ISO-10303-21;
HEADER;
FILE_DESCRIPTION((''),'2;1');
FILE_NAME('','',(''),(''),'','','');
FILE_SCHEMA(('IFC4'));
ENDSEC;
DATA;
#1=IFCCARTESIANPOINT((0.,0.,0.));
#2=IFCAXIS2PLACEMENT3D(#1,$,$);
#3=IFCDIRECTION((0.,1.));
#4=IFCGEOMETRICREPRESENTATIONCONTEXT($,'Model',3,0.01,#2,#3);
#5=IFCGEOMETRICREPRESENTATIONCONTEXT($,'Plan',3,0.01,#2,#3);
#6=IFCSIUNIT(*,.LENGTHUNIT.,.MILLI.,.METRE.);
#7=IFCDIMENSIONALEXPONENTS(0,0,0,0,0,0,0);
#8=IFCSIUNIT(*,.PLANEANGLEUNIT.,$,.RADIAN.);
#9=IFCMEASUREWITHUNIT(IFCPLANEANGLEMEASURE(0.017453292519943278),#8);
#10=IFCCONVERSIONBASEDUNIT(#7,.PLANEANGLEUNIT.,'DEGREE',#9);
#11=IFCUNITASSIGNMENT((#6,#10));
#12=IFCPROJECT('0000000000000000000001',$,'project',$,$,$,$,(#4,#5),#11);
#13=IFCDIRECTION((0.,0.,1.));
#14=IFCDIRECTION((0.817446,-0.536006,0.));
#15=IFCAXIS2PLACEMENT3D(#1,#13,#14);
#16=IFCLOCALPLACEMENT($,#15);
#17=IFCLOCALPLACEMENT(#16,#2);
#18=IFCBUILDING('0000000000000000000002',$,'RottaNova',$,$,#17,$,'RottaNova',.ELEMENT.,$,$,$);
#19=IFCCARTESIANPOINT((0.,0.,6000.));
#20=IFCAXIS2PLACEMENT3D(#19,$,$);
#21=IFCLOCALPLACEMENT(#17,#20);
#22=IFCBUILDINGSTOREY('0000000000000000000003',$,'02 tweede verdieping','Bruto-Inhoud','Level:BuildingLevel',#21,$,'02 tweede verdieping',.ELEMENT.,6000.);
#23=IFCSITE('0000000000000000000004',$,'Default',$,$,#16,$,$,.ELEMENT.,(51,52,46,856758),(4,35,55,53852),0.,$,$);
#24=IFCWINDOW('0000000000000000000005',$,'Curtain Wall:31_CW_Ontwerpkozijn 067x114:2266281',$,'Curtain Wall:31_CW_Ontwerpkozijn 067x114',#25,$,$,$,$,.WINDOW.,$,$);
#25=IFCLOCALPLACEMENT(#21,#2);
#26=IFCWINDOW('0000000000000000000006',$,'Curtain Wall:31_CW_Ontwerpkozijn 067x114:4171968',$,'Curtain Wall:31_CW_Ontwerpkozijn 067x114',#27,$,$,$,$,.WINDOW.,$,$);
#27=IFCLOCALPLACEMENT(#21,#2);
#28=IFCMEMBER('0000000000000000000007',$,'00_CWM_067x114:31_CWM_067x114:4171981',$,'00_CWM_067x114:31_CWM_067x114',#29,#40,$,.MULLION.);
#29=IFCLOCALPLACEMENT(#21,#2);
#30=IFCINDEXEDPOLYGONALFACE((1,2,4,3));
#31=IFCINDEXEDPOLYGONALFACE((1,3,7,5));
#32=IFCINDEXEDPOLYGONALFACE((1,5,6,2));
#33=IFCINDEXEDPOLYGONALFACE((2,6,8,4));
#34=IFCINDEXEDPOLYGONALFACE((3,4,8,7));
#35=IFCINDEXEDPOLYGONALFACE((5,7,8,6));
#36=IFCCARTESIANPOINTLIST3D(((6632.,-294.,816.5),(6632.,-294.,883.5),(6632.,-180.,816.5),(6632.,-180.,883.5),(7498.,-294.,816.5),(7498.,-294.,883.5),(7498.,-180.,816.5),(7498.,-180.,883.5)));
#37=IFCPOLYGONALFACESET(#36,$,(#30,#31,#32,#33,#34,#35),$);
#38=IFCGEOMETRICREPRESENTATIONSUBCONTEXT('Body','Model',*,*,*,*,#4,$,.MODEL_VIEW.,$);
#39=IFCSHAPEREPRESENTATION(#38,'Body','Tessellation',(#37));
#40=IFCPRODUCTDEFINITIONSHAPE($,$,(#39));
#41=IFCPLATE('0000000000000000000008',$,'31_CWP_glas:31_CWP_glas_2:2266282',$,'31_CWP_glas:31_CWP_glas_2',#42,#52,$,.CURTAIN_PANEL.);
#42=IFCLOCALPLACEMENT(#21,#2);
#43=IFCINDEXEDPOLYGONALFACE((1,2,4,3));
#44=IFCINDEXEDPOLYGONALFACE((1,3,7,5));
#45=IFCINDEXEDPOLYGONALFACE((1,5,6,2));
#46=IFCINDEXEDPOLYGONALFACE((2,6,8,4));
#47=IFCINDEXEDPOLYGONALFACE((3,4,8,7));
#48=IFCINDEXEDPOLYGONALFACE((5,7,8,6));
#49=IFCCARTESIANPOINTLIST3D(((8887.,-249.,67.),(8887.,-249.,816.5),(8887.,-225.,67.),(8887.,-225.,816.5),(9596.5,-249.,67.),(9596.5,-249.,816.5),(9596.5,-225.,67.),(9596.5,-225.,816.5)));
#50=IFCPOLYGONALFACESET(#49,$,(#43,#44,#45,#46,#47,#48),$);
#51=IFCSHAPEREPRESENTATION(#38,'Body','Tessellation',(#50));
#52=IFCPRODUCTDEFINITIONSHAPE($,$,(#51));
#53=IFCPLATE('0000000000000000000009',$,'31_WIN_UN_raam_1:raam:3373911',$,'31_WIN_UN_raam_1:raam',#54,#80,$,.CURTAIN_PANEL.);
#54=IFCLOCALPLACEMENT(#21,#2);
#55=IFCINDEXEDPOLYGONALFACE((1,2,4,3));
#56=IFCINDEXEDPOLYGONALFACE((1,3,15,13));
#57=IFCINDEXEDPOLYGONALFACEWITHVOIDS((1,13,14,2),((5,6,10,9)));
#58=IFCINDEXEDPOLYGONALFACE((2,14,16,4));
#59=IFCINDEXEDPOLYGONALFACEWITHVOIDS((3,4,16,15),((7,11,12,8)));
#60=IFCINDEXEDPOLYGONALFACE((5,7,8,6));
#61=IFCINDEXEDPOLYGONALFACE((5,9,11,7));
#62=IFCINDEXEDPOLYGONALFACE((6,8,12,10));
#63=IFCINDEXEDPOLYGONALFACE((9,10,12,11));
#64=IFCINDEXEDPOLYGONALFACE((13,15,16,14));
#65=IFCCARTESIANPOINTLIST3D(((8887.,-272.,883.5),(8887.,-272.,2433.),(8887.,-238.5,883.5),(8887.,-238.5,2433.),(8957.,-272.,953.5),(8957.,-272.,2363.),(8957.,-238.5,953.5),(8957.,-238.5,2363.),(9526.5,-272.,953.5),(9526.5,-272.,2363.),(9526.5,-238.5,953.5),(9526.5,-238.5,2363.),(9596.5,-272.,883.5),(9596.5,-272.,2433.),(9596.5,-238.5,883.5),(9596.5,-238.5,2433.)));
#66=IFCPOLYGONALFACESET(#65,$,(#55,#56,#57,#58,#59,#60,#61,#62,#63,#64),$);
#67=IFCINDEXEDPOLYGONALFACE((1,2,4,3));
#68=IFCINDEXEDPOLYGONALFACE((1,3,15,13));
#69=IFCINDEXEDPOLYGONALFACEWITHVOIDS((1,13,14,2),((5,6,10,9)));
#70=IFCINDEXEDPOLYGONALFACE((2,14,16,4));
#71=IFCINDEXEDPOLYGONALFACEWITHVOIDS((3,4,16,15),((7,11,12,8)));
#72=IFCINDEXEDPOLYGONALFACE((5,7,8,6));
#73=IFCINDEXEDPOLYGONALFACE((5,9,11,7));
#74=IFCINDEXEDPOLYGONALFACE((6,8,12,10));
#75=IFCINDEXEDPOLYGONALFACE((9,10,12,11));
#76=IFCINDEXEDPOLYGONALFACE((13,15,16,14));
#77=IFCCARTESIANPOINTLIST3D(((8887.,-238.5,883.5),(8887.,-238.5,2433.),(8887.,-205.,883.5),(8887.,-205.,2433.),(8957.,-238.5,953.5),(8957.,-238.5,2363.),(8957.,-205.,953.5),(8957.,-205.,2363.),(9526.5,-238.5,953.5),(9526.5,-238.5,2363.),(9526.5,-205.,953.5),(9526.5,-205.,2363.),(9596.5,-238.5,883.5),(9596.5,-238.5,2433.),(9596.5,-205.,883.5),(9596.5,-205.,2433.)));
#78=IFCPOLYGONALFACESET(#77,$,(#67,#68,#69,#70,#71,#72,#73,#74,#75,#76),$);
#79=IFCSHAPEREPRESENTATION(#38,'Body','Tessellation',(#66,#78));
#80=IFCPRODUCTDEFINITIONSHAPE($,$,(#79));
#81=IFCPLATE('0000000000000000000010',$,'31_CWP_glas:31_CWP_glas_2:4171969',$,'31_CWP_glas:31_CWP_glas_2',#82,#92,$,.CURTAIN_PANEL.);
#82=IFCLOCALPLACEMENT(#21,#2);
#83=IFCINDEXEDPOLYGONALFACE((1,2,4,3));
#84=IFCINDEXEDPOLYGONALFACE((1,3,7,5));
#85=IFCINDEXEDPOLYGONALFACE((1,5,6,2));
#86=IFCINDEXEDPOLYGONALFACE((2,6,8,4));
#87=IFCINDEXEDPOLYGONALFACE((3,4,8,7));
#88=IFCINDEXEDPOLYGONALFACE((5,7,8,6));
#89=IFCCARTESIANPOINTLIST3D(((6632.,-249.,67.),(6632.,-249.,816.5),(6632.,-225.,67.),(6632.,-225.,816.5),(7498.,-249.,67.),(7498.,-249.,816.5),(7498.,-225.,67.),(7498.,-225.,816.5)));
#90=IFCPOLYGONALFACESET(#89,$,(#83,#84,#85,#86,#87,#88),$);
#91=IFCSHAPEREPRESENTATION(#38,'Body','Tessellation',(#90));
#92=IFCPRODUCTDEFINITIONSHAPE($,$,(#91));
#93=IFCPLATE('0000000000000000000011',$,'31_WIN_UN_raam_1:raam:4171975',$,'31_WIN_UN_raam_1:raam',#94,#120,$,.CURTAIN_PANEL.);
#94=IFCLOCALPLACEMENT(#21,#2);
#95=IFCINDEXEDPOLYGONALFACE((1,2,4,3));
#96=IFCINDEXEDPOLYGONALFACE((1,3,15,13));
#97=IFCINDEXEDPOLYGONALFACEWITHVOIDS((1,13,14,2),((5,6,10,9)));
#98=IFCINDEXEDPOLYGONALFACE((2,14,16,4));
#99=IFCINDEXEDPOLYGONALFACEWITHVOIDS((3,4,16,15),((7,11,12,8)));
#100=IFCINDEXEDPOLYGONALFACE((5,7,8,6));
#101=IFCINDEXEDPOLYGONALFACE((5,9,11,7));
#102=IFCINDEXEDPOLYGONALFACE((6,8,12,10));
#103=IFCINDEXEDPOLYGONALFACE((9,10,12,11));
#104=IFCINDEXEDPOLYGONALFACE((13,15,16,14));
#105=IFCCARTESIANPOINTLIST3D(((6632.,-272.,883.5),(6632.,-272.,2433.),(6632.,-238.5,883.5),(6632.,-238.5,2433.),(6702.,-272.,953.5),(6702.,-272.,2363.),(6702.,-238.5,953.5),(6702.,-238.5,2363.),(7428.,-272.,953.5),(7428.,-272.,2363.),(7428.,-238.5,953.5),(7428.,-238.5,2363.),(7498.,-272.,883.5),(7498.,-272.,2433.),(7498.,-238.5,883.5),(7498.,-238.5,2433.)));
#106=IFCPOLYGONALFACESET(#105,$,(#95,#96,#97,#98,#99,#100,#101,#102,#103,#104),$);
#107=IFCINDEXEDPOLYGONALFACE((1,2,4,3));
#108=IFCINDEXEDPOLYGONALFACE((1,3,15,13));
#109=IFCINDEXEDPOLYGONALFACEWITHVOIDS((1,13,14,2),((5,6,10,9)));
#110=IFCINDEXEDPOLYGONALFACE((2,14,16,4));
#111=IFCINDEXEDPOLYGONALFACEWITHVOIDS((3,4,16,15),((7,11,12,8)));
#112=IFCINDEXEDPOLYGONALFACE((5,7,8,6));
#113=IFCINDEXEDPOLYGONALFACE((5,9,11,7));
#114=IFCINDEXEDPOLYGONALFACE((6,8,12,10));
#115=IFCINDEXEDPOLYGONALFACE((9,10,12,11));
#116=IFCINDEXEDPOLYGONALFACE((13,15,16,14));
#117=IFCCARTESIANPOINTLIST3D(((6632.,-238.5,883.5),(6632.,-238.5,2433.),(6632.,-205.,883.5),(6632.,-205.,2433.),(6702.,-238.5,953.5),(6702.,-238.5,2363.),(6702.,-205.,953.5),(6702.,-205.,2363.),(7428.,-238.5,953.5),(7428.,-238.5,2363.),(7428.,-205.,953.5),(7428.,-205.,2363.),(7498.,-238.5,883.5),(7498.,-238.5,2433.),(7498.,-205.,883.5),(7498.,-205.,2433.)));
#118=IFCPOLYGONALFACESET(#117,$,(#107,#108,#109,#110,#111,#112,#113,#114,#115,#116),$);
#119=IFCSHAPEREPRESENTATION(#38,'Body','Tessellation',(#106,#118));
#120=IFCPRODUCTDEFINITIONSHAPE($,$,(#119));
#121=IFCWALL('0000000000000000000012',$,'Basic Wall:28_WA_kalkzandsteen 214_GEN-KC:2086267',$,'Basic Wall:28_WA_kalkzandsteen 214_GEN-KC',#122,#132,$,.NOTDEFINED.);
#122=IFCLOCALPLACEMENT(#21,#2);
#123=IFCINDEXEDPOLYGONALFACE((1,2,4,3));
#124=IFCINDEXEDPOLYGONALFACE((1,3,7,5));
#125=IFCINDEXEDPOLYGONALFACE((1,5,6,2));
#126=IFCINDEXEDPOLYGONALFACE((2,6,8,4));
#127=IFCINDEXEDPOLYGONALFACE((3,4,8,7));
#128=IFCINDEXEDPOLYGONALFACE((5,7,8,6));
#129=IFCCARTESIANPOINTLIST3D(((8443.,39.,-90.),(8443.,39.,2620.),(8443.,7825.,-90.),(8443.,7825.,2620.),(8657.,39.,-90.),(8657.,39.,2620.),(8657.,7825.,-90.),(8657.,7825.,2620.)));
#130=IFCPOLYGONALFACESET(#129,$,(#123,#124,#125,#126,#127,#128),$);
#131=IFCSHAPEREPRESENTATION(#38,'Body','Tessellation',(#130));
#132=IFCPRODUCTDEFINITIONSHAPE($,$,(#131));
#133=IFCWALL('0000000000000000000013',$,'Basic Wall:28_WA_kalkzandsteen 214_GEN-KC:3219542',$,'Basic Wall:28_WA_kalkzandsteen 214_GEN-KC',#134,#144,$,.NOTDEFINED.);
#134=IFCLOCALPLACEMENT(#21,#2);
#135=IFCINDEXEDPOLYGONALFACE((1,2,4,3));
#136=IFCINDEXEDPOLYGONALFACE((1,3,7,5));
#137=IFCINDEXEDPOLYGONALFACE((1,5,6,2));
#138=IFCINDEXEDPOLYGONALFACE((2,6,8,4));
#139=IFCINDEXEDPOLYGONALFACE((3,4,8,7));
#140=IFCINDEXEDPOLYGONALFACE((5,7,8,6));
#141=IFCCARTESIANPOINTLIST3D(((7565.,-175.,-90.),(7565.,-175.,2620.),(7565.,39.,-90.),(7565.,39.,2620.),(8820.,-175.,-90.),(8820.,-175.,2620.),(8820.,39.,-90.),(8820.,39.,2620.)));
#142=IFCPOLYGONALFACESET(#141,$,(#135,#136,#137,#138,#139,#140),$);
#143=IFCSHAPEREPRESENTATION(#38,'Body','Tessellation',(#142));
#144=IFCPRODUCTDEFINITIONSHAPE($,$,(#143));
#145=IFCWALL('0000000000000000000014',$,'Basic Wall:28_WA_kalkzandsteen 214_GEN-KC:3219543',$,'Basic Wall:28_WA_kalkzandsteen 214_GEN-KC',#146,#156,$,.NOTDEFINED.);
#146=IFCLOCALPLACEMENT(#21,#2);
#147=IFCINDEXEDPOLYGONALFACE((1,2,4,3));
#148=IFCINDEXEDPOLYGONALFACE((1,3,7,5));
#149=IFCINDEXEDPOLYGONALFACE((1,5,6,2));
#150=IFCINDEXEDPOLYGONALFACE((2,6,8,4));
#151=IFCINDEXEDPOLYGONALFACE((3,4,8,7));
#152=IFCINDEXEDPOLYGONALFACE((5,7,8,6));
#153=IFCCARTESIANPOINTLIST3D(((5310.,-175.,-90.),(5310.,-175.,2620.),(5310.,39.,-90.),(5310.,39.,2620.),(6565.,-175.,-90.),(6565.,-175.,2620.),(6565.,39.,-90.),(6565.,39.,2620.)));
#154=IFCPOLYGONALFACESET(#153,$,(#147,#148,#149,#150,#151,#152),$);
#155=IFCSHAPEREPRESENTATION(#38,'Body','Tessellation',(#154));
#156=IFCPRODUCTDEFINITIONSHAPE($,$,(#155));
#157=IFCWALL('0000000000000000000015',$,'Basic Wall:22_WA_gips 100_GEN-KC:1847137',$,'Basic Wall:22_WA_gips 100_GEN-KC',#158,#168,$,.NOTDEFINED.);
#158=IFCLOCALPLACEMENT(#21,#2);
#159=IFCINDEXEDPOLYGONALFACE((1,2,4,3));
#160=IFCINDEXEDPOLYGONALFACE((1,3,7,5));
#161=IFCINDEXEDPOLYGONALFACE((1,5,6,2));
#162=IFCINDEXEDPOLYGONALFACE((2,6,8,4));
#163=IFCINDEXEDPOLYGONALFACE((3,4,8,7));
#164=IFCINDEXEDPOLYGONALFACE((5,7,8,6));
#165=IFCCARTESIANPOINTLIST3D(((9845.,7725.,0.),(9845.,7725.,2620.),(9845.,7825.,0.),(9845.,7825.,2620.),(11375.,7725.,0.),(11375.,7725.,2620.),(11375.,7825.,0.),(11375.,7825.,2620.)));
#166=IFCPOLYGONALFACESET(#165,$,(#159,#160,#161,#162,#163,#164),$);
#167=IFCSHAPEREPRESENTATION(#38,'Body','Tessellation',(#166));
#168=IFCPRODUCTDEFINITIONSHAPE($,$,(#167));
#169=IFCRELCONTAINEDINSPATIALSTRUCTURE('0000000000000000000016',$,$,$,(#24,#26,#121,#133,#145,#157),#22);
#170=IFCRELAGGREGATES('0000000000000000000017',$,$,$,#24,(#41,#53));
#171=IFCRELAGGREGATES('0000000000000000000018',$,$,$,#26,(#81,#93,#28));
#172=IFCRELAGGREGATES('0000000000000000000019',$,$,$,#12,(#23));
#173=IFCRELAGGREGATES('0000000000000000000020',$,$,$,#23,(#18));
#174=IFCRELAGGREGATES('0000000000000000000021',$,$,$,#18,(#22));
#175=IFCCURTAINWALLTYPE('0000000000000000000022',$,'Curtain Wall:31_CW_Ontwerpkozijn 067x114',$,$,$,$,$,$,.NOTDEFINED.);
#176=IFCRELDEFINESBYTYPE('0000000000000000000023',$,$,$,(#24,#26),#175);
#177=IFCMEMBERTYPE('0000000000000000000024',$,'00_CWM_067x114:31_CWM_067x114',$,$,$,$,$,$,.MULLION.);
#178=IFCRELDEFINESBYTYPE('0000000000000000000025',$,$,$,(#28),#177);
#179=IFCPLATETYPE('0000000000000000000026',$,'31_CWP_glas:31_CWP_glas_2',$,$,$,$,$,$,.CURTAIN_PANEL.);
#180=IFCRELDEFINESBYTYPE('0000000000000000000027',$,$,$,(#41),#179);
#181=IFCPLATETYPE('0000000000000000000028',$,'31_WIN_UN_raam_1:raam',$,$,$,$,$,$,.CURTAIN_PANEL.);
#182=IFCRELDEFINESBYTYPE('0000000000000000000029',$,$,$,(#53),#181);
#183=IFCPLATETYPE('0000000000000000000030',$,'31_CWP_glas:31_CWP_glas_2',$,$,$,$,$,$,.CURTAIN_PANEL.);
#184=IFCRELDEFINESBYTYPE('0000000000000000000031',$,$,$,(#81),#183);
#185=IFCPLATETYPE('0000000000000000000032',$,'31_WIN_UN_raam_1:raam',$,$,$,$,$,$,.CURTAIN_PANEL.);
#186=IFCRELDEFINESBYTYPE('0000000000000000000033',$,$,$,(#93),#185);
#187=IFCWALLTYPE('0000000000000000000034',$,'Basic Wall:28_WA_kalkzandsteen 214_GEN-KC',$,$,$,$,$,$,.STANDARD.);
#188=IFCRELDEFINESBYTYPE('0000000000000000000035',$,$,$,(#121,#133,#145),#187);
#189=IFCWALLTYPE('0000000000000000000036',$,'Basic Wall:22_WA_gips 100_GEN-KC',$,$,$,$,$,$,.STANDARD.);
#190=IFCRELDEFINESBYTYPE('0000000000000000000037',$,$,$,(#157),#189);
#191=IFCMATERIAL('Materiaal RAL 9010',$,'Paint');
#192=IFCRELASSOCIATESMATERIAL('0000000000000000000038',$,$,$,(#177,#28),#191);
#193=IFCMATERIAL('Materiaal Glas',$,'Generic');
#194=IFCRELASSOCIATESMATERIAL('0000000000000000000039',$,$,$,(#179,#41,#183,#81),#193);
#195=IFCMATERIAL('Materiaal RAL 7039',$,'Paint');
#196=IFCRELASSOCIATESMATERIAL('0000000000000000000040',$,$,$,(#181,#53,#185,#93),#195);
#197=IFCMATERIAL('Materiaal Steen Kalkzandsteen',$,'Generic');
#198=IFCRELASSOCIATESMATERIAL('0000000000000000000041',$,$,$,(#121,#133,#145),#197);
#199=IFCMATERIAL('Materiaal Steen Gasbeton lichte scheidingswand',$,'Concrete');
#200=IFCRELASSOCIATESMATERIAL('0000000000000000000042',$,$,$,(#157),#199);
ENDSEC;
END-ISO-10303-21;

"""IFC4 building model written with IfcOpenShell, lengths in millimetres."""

from ifc_helpers import new_model, entity, si_unit, converted_unit, direction, frame, origin, place, context, subcontext, project, spatial, indexed_curve, outline, extrude, source, transform, mapped, material, type_object, type_shapes, element, aggregate, save


model = new_model("IFC4")

# Units and contexts
model_context = context("Model", 3, precision=0.01, world=origin(), true_north=direction((0.0, 1.0)))
plan_context = context("Plan", 3, precision=0.01, world=origin(), true_north=direction((0.0, 1.0)))
body_context = subcontext(model_context, "Body", "Model", "MODEL_VIEW")
ifc_project = project(units=[si_unit("LENGTHUNIT", "METRE", prefix="MILLI"), converted_unit("PLANEANGLEUNIT", "DEGREE", entity("IfcPlaneAngleMeasure", 0.017453292519943278), si_unit("PLANEANGLEUNIT", "RADIAN"), dimensions=[0, 0, 0, 0, 0, 0, 0])], contexts=[model_context, plan_context])

# Site, building, storey
site_placement = place(None, frame((0.0, 0.0, 0.0), z_axis=(0.0, 0.0, 1.0), x_axis=(0.817446, -0.536006, 0.0)))
site = spatial("IfcSite", under=ifc_project, at=site_placement, Name="Default", CompositionType="ELEMENT", RefLatitude=(51, 52, 46, 856758), RefLongitude=(4, 35, 55, 53852), RefElevation=0.0)
building_placement = place(site_placement, origin())
building = spatial("IfcBuilding", under=site, at=building_placement, Name="RottaNova", LongName="RottaNova", CompositionType="ELEMENT")
storey_placement = place(building_placement, frame((0.0, 0.0, 6000.0)))
storey = spatial("IfcBuildingStorey", under=building, at=storey_placement, Name="02 tweede verdieping", Description="Bruto-Inhoud", ObjectType="Level:BuildingLevel", LongName="02 tweede verdieping", CompositionType="ELEMENT", Elevation=6000.0)

# Windows
curtain_wall_type = type_object("IfcCurtainWallType", Name="Curtain Wall:31_CW_Ontwerpkozijn 067x114", PredefinedType="NOTDEFINED")
window_1_placement = place(storey_placement, frame((0.0, 0.0, -6000.0)))
window_1 = element("IfcWindow", 1, at=window_1_placement, inside=storey, type_object=curtain_wall_type, Name="Curtain Wall:31_CW_Ontwerpkozijn 067x114:2266281", ObjectType="Curtain Wall:31_CW_Ontwerpkozijn 067x114", PredefinedType="WINDOW")
ifc_material_1 = material(Name="Materiaal RAL 9010", Category="Paint")
window_2_placement = place(storey_placement, frame((0.0, 0.0, -6000.0)))
window_2 = element("IfcWindow", 2, at=window_2_placement, inside=storey, type_object=curtain_wall_type, Name="Curtain Wall:31_CW_Ontwerpkozijn 067x114:4171968", ObjectType="Curtain Wall:31_CW_Ontwerpkozijn 067x114", PredefinedType="WINDOW")

# Member
member_type_1 = type_object("IfcMemberType", Name="00_CWM_067x114:31_CWM_067x114", PredefinedType="MULLION", material=ifc_material_1)
shared_shape_1 = source(origin(), body_context, "Body", "SweptSolid", [
    extrude(outline(indexed_curve([(-33.5, -57.0), (33.5, -57.0), (33.5, 57.0), (-33.5, 57.0), (-33.5, -57.0)], self_intersect=False)), frame((0.0, 57.0, -866.0), z_axis=(0.0, 0.0, 1.0), x_axis=(-1.0, 0.0, 0.0)), (0.0, 0.0, 1.0), 866.0),
])
type_shapes(member_type_1, [shared_shape_1])
member_1_placement = place(window_2_placement, frame((7498.0, -180.0, 6850.0), z_axis=(1.0, 0.0, 0.0), x_axis=(0.0, 0.0, 1.0)))
member_1 = element("IfcMember", 3, at=member_1_placement, type_object=member_type_1, material=ifc_material_1, Name="00_CWM_067x114:31_CWM_067x114:4171981", ObjectType="00_CWM_067x114:31_CWM_067x114", PredefinedType="MULLION", context=body_context, shape_type="MappedRepresentation", body=[
    mapped(shared_shape_1, transform((0.0, 0.0, 0.0), scale=1.0)),
])

# Plates
ifc_material_2 = material(Name="Materiaal Glas", Category="Generic")
plate_type_1 = type_object("IfcPlateType", Name="31_CWP_glas:31_CWP_glas_2", PredefinedType="CURTAIN_PANEL", material=ifc_material_2)
shared_shape_2 = source(origin(), body_context, "Body", "SweptSolid", [
    extrude(outline(indexed_curve([(-12.0, -354.8), (12.0, -354.8), (12.0, 354.8), (-12.0, 354.8), (-12.0, -354.8)], self_intersect=False)), frame((0.0, -57.0, 0.0), z_axis=(0.0, 0.0, 1.0), x_axis=(0.0, 1.0, 0.0)), (0.0, 0.0, 1.0), 749.5),
])
type_shapes(plate_type_1, [shared_shape_2])
plate_1_placement = place(window_1_placement, frame((9241.7, -180.0, 6067.0)))
plate_1 = element("IfcPlate", 4, at=plate_1_placement, type_object=plate_type_1, material=ifc_material_2, Name="31_CWP_glas:31_CWP_glas_2:2266282", ObjectType="31_CWP_glas:31_CWP_glas_2", PredefinedType="CURTAIN_PANEL", context=body_context, shape_type="MappedRepresentation", body=[
    mapped(shared_shape_2, transform((0.0, 0.0, 0.0), scale=1.0)),
])
ifc_material_3 = material(Name="Materiaal RAL 7039", Category="Paint")
plate_type_2 = type_object("IfcPlateType", Name="31_WIN_UN_raam_1:raam", PredefinedType="CURTAIN_PANEL", material=ifc_material_3)
shared_shape_3 = source(origin(), body_context, "Body", "SweptSolid", [
    extrude(outline(indexed_curve([(-354.7, -774.7), (354.7, -774.7), (354.7, 774.7), (-354.7, 774.7), (-354.7, -774.7)], self_intersect=False), holes=[indexed_curve([(-284.7, 704.7), (284.7, 704.7), (284.7, -704.8), (-284.7, -704.8), (-284.7, 704.7)], self_intersect=False)]), frame((0.0, -92.0, 774.8), z_axis=(0.0, 1.0, 0.0), x_axis=(1.0, 0.0, 0.0)), (0.0, 0.0, 1.0), 33.5),
    extrude(outline(indexed_curve([(-354.7, -774.7), (354.7, -774.7), (354.7, 774.7), (-354.7, 774.7), (-354.7, -774.7)], self_intersect=False), holes=[indexed_curve([(-284.7, 704.7), (284.7, 704.7), (284.7, -704.8), (-284.7, -704.8), (-284.7, 704.7)], self_intersect=False)]), frame((0.0, -58.5, 774.8), z_axis=(0.0, 1.0, 0.0), x_axis=(1.0, 0.0, 0.0)), (0.0, 0.0, 1.0), 33.5),
])
type_shapes(plate_type_2, [shared_shape_3])
plate_2_placement = place(window_1_placement, frame((9241.7, -180.0, 6883.5)))
plate_2 = element("IfcPlate", 5, at=plate_2_placement, type_object=plate_type_2, material=ifc_material_3, Name="31_WIN_UN_raam_1:raam:3373911", ObjectType="31_WIN_UN_raam_1:raam", PredefinedType="CURTAIN_PANEL", context=body_context, shape_type="MappedRepresentation", body=[
    mapped(shared_shape_3, transform((0.0, 0.0, 0.0), scale=1.0)),
])
aggregate(window_1, [plate_1, plate_2])
plate_type_3 = type_object("IfcPlateType", Name="31_CWP_glas:31_CWP_glas_2", PredefinedType="CURTAIN_PANEL", material=ifc_material_2)
shared_shape_4 = source(origin(), body_context, "Body", "SweptSolid", [
    extrude(outline(indexed_curve([(-12.0, -433.0), (12.0, -433.0), (12.0, 433.0), (-12.0, 433.0), (-12.0, -433.0)], self_intersect=False)), frame((0.0, -57.0, 0.0), z_axis=(0.0, 0.0, 1.0), x_axis=(0.0, 1.0, 0.0)), (0.0, 0.0, 1.0), 749.5),
])
type_shapes(plate_type_3, [shared_shape_4])
plate_3_placement = place(window_2_placement, frame((7065.0, -180.0, 6067.0)))
plate_3 = element("IfcPlate", 6, at=plate_3_placement, type_object=plate_type_3, material=ifc_material_2, Name="31_CWP_glas:31_CWP_glas_2:4171969", ObjectType="31_CWP_glas:31_CWP_glas_2", PredefinedType="CURTAIN_PANEL", context=body_context, shape_type="MappedRepresentation", body=[
    mapped(shared_shape_4, transform((0.0, 0.0, 0.0), scale=1.0)),
])
plate_type_4 = type_object("IfcPlateType", Name="31_WIN_UN_raam_1:raam", PredefinedType="CURTAIN_PANEL", material=ifc_material_3)
shared_shape_5 = source(origin(), body_context, "Body", "SweptSolid", [
    extrude(outline(indexed_curve([(-433.0, -774.7), (433.0, -774.7), (433.0, 774.7), (-433.0, 774.7), (-433.0, -774.7)], self_intersect=False), holes=[indexed_curve([(-363.0, 704.7), (363.0, 704.7), (363.0, -704.8), (-363.0, -704.8), (-363.0, 704.7)], self_intersect=False)]), frame((0.0, -92.0, 774.8), z_axis=(0.0, 1.0, 0.0), x_axis=(1.0, 0.0, 0.0)), (0.0, 0.0, 1.0), 33.5),
    extrude(outline(indexed_curve([(-433.0, -774.7), (433.0, -774.7), (433.0, 774.7), (-433.0, 774.7), (-433.0, -774.7)], self_intersect=False), holes=[indexed_curve([(-363.0, 704.7), (363.0, 704.7), (363.0, -704.8), (-363.0, -704.8), (-363.0, 704.7)], self_intersect=False)]), frame((0.0, -58.5, 774.8), z_axis=(0.0, 1.0, 0.0), x_axis=(1.0, 0.0, 0.0)), (0.0, 0.0, 1.0), 33.5),
])
type_shapes(plate_type_4, [shared_shape_5])
plate_4_placement = place(window_2_placement, frame((7065.0, -180.0, 6883.5)))
plate_4 = element("IfcPlate", 7, at=plate_4_placement, type_object=plate_type_4, material=ifc_material_3, Name="31_WIN_UN_raam_1:raam:4171975", ObjectType="31_WIN_UN_raam_1:raam", PredefinedType="CURTAIN_PANEL", context=body_context, shape_type="MappedRepresentation", body=[
    mapped(shared_shape_5, transform((0.0, 0.0, 0.0), scale=1.0)),
])
aggregate(window_2, [plate_3, plate_4, member_1])

# Walls
ifc_material_4 = material(Name="Materiaal Steen Kalkzandsteen", Category="Generic")
wall_type_1 = type_object("IfcWallType", Name="Basic Wall:28_WA_kalkzandsteen 214_GEN-KC", PredefinedType="STANDARD")
wall_1_placement = place(storey_placement, frame((8550.0, 39.0, -90.0), z_axis=(0.0, 0.0, 1.0), x_axis=(0.0, 1.0, 0.0)))
element("IfcWall", 8, at=wall_1_placement, inside=storey, type_object=wall_type_1, material=ifc_material_4, Name="Basic Wall:28_WA_kalkzandsteen 214_GEN-KC:2086267", ObjectType="Basic Wall:28_WA_kalkzandsteen 214_GEN-KC", PredefinedType="NOTDEFINED", context=body_context, shape_type="SweptSolid", body=[
    extrude(outline(indexed_curve([(-3893.0, -107.0), (3893.0, -107.0), (3893.0, 107.0), (-3893.0, 107.0), (-3893.0, -107.0)], self_intersect=False)), frame((3893.0, 0.0, 0.0)), (0.0, 0.0, 1.0), 2710.0),
])
wall_2_placement = place(storey_placement, frame((8820.0, -68.0, -90.0), z_axis=(0.0, 0.0, 1.0), x_axis=(-1.0, 0.0, 0.0)))
element("IfcWall", 9, at=wall_2_placement, inside=storey, type_object=wall_type_1, material=ifc_material_4, Name="Basic Wall:28_WA_kalkzandsteen 214_GEN-KC:3219542", ObjectType="Basic Wall:28_WA_kalkzandsteen 214_GEN-KC", PredefinedType="NOTDEFINED", context=body_context, shape_type="SweptSolid", body=[
    extrude(outline(indexed_curve([(1255.0, 107.0), (0.0, 107.0), (0.0, -107.0), (1255.0, -107.0), (1255.0, 107.0)], self_intersect=False)), origin(), (0.0, 0.0, 1.0), 2710.0),
])
wall_3_placement = place(storey_placement, frame((6565.0, -68.0, -90.0), z_axis=(0.0, 0.0, 1.0), x_axis=(-1.0, 0.0, 0.0)))
element("IfcWall", 10, at=wall_3_placement, inside=storey, type_object=wall_type_1, material=ifc_material_4, Name="Basic Wall:28_WA_kalkzandsteen 214_GEN-KC:3219543", ObjectType="Basic Wall:28_WA_kalkzandsteen 214_GEN-KC", PredefinedType="NOTDEFINED", context=body_context, shape_type="SweptSolid", body=[
    extrude(outline(indexed_curve([(1255.0, 107.0), (0.0, 107.0), (0.0, -107.0), (1255.0, -107.0), (1255.0, 107.0)], self_intersect=False)), origin(), (0.0, 0.0, 1.0), 2710.0),
])
ifc_material_5 = material(Name="Materiaal Steen Gasbeton lichte scheidingswand", Category="Concrete")
wall_type_2 = type_object("IfcWallType", Name="Basic Wall:22_WA_gips 100_GEN-KC", PredefinedType="STANDARD")
wall_4_placement = place(storey_placement, frame((9845.0, 7775.0, 0.0)))
element("IfcWall", 11, at=wall_4_placement, inside=storey, type_object=wall_type_2, material=ifc_material_5, Name="Basic Wall:22_WA_gips 100_GEN-KC:1847137", ObjectType="Basic Wall:22_WA_gips 100_GEN-KC", PredefinedType="NOTDEFINED", context=body_context, shape_type="SweptSolid", body=[
    extrude(outline(indexed_curve([(1530.0, 50.0), (0.0, 50.0), (0.0, -50.0), (1530.0, -50.0), (1530.0, 50.0)], self_intersect=False)), origin(), (0.0, 0.0, 1.0), 2620.0),
])

save(model, "model.ifc")
